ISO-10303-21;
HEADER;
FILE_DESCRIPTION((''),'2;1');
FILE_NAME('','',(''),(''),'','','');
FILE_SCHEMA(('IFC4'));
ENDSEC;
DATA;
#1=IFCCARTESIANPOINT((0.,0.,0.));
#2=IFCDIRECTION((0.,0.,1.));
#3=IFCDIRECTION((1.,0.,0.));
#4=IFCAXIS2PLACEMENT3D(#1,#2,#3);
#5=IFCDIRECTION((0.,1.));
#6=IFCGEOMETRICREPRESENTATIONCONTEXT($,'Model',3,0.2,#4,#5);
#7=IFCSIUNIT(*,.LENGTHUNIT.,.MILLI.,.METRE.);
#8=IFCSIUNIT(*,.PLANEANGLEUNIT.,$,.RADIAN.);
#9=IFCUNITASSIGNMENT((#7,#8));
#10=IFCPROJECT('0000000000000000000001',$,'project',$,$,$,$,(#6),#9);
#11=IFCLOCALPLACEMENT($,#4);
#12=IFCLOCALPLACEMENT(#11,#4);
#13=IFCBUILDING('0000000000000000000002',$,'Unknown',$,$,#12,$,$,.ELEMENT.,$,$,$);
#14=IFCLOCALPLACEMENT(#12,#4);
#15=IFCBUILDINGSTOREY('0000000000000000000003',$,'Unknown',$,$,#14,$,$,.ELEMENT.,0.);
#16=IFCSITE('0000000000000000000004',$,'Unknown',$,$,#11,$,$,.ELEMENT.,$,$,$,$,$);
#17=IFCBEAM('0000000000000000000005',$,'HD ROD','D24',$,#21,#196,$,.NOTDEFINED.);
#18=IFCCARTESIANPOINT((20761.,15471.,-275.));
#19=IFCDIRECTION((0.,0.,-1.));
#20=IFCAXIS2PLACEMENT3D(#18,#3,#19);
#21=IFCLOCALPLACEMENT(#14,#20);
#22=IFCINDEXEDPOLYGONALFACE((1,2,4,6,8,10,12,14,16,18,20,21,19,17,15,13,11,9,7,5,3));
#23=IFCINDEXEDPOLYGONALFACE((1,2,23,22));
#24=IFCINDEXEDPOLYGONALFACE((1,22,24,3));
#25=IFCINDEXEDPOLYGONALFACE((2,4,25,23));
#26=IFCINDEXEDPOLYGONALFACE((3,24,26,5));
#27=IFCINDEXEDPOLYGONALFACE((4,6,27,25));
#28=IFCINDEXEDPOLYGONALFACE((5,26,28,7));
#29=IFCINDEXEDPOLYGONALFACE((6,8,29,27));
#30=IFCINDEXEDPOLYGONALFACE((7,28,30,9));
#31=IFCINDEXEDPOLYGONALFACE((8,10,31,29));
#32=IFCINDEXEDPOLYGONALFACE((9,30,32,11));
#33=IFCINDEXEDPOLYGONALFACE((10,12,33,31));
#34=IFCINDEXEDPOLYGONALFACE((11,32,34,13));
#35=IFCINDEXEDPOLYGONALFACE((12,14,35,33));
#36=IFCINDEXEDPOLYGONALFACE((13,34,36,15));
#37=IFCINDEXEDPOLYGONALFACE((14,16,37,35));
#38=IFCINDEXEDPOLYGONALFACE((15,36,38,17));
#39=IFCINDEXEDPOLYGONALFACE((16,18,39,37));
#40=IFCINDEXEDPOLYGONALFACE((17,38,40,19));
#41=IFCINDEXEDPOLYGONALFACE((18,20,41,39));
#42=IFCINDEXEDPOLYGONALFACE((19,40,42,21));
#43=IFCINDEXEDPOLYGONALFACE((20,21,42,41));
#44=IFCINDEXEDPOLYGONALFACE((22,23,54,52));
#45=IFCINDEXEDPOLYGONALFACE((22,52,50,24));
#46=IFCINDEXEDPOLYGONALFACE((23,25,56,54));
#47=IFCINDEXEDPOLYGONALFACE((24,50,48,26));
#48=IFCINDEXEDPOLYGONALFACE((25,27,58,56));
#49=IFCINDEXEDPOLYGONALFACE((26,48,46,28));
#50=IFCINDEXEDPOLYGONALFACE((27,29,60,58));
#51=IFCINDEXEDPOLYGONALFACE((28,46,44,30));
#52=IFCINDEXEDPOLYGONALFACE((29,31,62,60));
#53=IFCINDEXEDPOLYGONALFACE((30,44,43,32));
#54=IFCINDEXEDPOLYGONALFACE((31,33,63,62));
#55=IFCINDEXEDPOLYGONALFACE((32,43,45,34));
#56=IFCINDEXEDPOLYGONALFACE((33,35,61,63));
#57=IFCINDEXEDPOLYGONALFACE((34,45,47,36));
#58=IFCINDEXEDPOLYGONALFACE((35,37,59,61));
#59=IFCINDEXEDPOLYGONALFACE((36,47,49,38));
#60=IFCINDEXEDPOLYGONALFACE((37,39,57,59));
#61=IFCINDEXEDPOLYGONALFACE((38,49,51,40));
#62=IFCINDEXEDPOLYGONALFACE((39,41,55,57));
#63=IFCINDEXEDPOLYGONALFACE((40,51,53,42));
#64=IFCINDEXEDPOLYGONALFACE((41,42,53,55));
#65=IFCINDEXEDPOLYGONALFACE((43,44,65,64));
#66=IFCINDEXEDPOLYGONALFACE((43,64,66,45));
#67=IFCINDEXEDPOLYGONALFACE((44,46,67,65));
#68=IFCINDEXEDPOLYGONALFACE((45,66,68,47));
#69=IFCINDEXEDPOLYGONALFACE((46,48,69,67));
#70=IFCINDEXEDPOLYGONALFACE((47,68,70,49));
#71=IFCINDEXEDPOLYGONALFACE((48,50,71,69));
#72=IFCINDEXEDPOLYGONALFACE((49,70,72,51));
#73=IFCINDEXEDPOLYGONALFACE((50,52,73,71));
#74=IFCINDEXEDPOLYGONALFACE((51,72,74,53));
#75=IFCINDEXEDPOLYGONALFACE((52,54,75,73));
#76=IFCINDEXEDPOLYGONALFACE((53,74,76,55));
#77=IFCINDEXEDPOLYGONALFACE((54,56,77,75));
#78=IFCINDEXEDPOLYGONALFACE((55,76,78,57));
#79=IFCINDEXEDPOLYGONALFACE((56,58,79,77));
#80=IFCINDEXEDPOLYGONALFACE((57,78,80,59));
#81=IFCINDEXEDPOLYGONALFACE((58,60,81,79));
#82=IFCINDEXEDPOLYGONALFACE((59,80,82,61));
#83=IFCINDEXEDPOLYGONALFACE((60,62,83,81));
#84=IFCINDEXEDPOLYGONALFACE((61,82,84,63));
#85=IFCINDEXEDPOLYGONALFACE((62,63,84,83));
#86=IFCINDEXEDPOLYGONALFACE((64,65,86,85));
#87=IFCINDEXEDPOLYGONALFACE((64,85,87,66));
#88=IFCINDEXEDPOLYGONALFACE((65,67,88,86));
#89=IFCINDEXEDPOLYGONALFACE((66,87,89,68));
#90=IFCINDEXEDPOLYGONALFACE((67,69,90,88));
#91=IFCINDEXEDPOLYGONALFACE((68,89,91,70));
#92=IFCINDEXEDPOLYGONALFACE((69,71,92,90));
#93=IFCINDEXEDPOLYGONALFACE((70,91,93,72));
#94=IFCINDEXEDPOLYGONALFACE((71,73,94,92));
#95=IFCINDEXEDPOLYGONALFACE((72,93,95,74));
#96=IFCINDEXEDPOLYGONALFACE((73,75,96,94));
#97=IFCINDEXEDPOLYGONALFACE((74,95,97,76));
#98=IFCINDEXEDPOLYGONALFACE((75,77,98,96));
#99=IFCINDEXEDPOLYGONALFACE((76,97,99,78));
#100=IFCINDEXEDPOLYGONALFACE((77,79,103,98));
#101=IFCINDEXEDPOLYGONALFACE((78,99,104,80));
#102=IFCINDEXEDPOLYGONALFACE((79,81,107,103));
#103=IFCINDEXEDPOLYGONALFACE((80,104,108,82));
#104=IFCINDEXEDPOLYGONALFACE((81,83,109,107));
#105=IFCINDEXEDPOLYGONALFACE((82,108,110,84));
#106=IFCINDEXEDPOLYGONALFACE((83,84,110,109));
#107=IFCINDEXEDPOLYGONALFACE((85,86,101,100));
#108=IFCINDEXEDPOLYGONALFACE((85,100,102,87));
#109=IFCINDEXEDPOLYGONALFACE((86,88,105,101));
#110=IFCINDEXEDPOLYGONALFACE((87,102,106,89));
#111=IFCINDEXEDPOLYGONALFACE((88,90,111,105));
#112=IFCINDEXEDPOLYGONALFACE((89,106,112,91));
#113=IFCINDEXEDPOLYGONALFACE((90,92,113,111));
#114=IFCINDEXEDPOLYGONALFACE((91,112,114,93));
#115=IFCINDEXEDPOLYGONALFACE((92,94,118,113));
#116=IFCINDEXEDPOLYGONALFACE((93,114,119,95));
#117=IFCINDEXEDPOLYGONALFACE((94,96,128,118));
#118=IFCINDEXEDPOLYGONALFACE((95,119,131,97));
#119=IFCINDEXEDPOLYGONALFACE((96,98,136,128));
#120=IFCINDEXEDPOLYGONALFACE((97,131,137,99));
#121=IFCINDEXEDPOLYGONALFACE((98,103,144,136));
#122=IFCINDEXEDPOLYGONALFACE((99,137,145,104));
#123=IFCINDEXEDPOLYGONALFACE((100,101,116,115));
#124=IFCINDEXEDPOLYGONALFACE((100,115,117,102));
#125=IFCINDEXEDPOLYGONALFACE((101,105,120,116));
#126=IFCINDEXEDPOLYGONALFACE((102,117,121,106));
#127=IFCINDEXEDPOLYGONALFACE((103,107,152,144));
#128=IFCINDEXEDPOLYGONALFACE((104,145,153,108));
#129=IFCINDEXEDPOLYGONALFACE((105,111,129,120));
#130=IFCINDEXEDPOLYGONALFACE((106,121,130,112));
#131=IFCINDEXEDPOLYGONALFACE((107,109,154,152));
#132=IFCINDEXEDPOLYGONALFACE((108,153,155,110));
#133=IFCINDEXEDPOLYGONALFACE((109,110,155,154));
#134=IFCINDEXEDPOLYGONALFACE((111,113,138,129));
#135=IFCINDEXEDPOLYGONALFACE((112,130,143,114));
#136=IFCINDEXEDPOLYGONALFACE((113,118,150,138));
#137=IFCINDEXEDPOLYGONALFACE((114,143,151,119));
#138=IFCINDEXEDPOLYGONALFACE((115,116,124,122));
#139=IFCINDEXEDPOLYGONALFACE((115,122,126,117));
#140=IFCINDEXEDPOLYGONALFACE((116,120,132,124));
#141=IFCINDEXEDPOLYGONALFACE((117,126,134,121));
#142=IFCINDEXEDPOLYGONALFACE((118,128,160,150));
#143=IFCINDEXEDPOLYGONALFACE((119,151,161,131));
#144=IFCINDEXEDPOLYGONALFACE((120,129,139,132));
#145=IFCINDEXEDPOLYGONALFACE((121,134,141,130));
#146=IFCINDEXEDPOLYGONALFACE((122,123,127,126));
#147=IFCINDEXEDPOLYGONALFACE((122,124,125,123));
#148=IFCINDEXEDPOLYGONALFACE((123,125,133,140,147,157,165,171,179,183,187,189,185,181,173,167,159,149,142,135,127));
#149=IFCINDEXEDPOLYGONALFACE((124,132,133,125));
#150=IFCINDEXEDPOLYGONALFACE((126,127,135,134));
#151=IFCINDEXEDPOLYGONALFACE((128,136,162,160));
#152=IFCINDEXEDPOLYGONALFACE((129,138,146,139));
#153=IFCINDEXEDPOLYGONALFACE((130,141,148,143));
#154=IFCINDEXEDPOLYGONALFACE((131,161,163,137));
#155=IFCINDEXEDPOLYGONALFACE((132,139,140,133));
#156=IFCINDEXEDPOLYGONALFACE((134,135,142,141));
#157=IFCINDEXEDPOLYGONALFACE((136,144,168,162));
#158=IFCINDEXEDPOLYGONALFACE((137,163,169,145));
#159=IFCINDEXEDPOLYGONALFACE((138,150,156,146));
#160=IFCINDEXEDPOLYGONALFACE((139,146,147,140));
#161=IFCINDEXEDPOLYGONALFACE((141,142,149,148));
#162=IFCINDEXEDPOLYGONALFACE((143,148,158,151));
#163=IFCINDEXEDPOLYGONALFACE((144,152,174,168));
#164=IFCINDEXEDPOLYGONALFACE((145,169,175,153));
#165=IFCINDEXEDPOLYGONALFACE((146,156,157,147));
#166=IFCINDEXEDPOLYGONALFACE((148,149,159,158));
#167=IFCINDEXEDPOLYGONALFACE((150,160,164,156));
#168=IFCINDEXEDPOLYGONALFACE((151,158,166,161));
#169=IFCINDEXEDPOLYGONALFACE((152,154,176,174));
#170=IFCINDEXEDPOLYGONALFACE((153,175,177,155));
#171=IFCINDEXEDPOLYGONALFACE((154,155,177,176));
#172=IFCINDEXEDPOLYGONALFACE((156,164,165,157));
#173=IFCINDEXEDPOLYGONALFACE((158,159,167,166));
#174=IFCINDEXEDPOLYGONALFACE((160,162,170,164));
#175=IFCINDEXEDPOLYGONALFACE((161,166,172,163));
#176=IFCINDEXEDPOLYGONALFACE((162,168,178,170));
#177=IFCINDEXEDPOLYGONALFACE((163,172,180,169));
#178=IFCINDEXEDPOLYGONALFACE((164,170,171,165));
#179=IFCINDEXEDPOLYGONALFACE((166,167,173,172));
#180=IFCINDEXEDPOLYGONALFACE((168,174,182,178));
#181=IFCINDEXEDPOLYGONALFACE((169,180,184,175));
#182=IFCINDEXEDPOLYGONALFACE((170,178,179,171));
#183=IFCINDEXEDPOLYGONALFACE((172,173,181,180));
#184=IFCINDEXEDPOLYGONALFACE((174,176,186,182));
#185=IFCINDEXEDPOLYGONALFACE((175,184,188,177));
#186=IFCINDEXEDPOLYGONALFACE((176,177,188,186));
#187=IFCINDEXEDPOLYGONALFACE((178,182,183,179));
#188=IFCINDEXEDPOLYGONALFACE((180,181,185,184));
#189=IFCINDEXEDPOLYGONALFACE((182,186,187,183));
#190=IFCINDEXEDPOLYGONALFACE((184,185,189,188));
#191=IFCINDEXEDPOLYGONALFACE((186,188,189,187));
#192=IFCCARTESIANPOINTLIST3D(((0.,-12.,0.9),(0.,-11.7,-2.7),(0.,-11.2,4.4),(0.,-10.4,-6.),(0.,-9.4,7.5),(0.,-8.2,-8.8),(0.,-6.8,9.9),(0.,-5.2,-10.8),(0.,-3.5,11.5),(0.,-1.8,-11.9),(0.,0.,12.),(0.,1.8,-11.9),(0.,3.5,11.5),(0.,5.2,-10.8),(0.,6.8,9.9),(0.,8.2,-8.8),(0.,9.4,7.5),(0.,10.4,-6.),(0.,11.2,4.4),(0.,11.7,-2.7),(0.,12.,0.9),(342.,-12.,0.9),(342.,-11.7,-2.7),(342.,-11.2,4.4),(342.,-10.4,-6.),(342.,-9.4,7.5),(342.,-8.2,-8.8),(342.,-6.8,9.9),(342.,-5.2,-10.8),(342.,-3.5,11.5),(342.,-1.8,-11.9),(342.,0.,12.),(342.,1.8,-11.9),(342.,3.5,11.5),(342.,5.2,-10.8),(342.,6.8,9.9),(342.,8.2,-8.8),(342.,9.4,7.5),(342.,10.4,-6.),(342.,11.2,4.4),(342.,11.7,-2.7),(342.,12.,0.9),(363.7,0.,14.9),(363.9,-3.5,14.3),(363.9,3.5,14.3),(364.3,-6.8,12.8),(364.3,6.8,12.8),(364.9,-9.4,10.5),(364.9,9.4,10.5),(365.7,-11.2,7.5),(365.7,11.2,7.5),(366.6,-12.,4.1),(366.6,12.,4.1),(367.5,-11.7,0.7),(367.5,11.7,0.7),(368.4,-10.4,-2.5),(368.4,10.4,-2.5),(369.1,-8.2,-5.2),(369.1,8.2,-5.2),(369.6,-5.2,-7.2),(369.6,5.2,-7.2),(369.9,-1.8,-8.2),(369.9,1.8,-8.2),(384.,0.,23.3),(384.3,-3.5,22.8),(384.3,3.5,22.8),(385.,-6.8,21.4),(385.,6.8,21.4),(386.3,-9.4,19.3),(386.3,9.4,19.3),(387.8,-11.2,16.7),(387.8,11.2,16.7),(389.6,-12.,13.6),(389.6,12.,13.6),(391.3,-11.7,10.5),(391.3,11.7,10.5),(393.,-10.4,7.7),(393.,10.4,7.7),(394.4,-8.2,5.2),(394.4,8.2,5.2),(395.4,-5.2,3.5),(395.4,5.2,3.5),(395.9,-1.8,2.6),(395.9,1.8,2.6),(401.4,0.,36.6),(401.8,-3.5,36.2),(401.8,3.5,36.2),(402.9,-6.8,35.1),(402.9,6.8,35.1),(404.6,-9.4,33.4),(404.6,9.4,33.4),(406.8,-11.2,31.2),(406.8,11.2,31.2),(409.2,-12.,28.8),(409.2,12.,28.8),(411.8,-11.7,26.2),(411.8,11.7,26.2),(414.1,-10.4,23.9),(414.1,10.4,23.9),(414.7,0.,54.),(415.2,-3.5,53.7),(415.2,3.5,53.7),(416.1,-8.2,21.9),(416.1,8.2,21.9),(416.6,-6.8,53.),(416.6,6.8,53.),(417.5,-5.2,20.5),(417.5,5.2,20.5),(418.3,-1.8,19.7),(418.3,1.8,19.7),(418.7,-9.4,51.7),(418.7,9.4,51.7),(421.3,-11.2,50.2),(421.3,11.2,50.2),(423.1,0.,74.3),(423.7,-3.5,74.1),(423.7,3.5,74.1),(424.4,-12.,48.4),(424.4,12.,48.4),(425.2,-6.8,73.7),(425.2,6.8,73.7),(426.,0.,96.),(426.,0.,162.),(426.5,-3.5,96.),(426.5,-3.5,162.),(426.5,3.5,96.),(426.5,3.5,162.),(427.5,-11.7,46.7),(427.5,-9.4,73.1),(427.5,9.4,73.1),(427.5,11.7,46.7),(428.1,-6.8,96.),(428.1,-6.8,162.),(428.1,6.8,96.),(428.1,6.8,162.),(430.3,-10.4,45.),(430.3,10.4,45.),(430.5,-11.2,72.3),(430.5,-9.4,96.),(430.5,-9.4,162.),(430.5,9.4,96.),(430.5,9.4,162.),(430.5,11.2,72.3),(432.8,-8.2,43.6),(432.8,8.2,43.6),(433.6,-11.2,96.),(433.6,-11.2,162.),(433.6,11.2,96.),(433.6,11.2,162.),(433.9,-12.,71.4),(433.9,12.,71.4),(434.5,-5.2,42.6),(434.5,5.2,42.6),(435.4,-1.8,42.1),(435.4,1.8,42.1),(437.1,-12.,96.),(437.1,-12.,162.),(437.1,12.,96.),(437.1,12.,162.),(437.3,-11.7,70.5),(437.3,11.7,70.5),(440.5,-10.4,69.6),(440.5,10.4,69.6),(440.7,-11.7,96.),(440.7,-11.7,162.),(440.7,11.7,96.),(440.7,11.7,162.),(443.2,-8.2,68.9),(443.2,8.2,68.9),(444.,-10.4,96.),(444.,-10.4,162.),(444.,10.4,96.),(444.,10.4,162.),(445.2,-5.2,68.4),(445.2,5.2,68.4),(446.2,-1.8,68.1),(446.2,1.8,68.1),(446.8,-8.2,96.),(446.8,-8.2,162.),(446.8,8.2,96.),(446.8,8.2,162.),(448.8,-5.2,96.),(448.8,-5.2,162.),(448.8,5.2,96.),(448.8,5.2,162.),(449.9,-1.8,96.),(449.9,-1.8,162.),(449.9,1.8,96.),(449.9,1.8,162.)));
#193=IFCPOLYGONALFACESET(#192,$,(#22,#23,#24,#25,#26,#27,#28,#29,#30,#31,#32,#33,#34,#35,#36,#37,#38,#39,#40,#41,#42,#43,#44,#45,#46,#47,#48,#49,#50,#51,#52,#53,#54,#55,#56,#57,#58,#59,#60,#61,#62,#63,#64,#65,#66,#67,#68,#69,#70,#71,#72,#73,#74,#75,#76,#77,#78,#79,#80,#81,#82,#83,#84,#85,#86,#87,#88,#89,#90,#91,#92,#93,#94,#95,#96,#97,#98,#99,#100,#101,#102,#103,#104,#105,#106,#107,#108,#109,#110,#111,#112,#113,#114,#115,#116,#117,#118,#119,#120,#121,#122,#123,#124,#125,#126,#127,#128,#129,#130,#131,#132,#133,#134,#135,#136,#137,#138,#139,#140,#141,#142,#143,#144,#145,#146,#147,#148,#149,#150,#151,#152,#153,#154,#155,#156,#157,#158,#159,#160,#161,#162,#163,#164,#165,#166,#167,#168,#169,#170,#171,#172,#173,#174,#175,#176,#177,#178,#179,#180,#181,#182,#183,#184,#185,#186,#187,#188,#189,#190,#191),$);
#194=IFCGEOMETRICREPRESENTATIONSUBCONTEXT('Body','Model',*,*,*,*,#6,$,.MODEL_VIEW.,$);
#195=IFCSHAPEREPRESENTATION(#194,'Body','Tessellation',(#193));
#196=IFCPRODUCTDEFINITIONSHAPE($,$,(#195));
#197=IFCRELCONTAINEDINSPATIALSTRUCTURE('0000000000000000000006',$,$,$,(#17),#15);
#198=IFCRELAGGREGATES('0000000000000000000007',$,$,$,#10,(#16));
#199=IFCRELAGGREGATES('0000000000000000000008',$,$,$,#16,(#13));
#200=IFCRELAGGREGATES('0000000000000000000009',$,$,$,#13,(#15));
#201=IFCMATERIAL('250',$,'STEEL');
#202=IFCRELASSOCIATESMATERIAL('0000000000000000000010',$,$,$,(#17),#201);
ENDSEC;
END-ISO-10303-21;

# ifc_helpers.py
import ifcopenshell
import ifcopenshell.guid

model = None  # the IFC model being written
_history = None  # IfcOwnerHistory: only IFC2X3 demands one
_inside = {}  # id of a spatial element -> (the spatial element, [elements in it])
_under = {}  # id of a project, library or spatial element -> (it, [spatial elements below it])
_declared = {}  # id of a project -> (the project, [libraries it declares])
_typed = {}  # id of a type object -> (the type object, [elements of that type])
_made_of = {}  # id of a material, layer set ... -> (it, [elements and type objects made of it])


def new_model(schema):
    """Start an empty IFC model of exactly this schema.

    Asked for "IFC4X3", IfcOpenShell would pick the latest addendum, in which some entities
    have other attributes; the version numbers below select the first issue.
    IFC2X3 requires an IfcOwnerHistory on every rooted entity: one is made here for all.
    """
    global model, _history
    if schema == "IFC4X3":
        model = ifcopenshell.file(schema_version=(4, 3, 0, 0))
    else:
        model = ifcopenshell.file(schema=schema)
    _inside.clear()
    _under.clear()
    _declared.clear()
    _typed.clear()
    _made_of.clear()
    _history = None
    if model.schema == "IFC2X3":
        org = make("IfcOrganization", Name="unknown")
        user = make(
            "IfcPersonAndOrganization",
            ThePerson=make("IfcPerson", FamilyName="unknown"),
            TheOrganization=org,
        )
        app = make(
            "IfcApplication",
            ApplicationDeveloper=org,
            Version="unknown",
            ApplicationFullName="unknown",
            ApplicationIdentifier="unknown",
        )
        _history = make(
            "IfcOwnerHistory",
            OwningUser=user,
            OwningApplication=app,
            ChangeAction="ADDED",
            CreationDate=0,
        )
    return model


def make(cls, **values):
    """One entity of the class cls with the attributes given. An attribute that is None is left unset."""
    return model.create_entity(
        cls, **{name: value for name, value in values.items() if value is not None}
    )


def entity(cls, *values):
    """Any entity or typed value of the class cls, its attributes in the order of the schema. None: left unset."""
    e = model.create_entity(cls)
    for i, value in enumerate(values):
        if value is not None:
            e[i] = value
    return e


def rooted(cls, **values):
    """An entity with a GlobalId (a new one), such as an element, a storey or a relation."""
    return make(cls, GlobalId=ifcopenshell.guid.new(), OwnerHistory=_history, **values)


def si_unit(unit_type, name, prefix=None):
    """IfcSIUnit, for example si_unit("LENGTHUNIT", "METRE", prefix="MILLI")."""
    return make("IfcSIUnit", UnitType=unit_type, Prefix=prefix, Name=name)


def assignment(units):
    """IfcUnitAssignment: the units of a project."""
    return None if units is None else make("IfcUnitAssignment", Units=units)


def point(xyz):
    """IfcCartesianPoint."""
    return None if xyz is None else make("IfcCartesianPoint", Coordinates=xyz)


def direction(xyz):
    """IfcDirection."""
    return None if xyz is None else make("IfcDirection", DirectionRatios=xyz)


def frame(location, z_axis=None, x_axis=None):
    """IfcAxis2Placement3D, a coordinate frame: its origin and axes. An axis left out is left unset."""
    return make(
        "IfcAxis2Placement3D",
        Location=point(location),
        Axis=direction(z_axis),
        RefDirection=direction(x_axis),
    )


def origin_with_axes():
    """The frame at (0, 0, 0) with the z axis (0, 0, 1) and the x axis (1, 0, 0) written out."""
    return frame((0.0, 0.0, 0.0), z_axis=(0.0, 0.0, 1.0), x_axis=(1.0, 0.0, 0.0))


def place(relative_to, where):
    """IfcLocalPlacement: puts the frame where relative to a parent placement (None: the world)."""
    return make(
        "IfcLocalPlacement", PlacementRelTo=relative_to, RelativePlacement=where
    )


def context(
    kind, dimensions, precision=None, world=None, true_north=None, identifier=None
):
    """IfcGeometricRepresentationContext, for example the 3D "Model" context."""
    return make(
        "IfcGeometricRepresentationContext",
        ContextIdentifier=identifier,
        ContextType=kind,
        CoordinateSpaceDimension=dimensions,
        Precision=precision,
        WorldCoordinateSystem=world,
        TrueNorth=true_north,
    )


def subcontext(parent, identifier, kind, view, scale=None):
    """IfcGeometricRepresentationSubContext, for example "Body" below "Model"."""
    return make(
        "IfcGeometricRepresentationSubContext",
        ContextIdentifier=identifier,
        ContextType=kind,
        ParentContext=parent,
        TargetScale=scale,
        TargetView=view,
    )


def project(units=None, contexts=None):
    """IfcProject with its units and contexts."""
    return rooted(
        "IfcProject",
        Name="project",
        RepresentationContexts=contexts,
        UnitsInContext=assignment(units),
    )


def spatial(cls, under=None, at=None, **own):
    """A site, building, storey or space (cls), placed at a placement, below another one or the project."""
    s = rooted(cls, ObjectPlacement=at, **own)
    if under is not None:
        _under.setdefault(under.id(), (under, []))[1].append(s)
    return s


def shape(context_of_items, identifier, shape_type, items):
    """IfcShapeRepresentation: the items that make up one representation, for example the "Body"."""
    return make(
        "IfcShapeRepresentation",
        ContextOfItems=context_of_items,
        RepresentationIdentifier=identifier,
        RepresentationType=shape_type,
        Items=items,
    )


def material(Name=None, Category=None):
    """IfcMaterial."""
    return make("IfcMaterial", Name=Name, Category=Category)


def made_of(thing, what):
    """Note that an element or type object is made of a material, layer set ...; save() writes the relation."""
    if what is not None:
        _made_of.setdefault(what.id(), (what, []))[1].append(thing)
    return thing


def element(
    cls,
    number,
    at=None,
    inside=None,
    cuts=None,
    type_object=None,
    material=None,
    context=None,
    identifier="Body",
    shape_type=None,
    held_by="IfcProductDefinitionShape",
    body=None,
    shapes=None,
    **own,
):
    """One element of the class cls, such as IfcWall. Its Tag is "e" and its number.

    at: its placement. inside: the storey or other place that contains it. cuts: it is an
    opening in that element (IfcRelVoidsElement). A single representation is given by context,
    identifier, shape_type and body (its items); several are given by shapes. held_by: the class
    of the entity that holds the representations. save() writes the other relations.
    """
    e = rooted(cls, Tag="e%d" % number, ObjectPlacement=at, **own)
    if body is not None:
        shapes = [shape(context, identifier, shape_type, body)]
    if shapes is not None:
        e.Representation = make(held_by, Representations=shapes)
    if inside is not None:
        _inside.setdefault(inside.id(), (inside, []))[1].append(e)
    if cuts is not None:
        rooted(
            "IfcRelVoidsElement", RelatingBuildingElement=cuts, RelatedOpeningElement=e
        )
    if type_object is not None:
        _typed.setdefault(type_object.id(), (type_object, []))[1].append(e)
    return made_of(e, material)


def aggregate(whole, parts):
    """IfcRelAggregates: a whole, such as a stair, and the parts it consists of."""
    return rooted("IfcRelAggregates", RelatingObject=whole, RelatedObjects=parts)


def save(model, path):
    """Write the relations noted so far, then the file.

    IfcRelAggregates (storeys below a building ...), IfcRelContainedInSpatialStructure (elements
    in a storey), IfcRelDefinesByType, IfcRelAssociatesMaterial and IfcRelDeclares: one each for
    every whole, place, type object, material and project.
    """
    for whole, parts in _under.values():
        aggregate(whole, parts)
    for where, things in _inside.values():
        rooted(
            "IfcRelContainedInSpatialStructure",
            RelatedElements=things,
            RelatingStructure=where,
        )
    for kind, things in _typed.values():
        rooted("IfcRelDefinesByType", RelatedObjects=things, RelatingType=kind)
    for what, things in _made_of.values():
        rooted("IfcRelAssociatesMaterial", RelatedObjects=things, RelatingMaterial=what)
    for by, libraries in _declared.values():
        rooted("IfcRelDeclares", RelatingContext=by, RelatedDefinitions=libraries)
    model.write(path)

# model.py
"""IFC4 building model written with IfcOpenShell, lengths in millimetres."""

from ifc_helpers import new_model, entity, si_unit, direction, frame, origin_with_axes, place, context, subcontext, project, spatial, material, element, save


model = new_model("IFC4")

# Units and contexts
model_context = context("Model", 3, precision=0.2, world=origin_with_axes(), true_north=direction((0.0, 1.0)))
body_context = subcontext(model_context, "Body", "Model", "MODEL_VIEW")
ifc_project = project(units=[si_unit("LENGTHUNIT", "METRE", prefix="MILLI"), si_unit("PLANEANGLEUNIT", "RADIAN")], contexts=[model_context])

# Site, building, storey
site_placement = place(None, origin_with_axes())
site = spatial("IfcSite", under=ifc_project, at=site_placement, Name="Unknown", CompositionType="ELEMENT")
building_placement = place(site_placement, origin_with_axes())
building = spatial("IfcBuilding", under=site, at=building_placement, Name="Unknown", CompositionType="ELEMENT")
storey_placement = place(building_placement, origin_with_axes())
storey = spatial("IfcBuildingStorey", under=building, at=storey_placement, Name="Unknown", CompositionType="ELEMENT", Elevation=0.0)

# Shared definitions
ifc_material_1 = material(Name="250", Category="STEEL")

# Beam
beam_1_placement = place(storey_placement, frame((20761.0, 15471.0, -275.0), z_axis=(1.0, 0.0, 0.0), x_axis=(0.0, 0.0, -1.0)))
element("IfcBeam", 1, at=beam_1_placement, inside=storey, material=ifc_material_1, Name="HD ROD", Description="D24", PredefinedType="NOTDEFINED", context=body_context, shape_type="SolidModel", body=[
    entity("IfcSweptDiskSolid", entity("IfcIndexedPolyCurve", entity("IfcCartesianPointList3D", [[0.0, 0.0, 0.0], [342.0, 0.0, 0.0], [409.9, 0.0, 28.1], [438.0, 0.0, 96.0], [438.0, 0.0, 162.0]]), [entity("IfcLineIndex", [1, 2]), entity("IfcArcIndex", [2, 3, 4]), entity("IfcLineIndex", [4, 5])]), 12.0),
])

save(model, "model.ifc")
